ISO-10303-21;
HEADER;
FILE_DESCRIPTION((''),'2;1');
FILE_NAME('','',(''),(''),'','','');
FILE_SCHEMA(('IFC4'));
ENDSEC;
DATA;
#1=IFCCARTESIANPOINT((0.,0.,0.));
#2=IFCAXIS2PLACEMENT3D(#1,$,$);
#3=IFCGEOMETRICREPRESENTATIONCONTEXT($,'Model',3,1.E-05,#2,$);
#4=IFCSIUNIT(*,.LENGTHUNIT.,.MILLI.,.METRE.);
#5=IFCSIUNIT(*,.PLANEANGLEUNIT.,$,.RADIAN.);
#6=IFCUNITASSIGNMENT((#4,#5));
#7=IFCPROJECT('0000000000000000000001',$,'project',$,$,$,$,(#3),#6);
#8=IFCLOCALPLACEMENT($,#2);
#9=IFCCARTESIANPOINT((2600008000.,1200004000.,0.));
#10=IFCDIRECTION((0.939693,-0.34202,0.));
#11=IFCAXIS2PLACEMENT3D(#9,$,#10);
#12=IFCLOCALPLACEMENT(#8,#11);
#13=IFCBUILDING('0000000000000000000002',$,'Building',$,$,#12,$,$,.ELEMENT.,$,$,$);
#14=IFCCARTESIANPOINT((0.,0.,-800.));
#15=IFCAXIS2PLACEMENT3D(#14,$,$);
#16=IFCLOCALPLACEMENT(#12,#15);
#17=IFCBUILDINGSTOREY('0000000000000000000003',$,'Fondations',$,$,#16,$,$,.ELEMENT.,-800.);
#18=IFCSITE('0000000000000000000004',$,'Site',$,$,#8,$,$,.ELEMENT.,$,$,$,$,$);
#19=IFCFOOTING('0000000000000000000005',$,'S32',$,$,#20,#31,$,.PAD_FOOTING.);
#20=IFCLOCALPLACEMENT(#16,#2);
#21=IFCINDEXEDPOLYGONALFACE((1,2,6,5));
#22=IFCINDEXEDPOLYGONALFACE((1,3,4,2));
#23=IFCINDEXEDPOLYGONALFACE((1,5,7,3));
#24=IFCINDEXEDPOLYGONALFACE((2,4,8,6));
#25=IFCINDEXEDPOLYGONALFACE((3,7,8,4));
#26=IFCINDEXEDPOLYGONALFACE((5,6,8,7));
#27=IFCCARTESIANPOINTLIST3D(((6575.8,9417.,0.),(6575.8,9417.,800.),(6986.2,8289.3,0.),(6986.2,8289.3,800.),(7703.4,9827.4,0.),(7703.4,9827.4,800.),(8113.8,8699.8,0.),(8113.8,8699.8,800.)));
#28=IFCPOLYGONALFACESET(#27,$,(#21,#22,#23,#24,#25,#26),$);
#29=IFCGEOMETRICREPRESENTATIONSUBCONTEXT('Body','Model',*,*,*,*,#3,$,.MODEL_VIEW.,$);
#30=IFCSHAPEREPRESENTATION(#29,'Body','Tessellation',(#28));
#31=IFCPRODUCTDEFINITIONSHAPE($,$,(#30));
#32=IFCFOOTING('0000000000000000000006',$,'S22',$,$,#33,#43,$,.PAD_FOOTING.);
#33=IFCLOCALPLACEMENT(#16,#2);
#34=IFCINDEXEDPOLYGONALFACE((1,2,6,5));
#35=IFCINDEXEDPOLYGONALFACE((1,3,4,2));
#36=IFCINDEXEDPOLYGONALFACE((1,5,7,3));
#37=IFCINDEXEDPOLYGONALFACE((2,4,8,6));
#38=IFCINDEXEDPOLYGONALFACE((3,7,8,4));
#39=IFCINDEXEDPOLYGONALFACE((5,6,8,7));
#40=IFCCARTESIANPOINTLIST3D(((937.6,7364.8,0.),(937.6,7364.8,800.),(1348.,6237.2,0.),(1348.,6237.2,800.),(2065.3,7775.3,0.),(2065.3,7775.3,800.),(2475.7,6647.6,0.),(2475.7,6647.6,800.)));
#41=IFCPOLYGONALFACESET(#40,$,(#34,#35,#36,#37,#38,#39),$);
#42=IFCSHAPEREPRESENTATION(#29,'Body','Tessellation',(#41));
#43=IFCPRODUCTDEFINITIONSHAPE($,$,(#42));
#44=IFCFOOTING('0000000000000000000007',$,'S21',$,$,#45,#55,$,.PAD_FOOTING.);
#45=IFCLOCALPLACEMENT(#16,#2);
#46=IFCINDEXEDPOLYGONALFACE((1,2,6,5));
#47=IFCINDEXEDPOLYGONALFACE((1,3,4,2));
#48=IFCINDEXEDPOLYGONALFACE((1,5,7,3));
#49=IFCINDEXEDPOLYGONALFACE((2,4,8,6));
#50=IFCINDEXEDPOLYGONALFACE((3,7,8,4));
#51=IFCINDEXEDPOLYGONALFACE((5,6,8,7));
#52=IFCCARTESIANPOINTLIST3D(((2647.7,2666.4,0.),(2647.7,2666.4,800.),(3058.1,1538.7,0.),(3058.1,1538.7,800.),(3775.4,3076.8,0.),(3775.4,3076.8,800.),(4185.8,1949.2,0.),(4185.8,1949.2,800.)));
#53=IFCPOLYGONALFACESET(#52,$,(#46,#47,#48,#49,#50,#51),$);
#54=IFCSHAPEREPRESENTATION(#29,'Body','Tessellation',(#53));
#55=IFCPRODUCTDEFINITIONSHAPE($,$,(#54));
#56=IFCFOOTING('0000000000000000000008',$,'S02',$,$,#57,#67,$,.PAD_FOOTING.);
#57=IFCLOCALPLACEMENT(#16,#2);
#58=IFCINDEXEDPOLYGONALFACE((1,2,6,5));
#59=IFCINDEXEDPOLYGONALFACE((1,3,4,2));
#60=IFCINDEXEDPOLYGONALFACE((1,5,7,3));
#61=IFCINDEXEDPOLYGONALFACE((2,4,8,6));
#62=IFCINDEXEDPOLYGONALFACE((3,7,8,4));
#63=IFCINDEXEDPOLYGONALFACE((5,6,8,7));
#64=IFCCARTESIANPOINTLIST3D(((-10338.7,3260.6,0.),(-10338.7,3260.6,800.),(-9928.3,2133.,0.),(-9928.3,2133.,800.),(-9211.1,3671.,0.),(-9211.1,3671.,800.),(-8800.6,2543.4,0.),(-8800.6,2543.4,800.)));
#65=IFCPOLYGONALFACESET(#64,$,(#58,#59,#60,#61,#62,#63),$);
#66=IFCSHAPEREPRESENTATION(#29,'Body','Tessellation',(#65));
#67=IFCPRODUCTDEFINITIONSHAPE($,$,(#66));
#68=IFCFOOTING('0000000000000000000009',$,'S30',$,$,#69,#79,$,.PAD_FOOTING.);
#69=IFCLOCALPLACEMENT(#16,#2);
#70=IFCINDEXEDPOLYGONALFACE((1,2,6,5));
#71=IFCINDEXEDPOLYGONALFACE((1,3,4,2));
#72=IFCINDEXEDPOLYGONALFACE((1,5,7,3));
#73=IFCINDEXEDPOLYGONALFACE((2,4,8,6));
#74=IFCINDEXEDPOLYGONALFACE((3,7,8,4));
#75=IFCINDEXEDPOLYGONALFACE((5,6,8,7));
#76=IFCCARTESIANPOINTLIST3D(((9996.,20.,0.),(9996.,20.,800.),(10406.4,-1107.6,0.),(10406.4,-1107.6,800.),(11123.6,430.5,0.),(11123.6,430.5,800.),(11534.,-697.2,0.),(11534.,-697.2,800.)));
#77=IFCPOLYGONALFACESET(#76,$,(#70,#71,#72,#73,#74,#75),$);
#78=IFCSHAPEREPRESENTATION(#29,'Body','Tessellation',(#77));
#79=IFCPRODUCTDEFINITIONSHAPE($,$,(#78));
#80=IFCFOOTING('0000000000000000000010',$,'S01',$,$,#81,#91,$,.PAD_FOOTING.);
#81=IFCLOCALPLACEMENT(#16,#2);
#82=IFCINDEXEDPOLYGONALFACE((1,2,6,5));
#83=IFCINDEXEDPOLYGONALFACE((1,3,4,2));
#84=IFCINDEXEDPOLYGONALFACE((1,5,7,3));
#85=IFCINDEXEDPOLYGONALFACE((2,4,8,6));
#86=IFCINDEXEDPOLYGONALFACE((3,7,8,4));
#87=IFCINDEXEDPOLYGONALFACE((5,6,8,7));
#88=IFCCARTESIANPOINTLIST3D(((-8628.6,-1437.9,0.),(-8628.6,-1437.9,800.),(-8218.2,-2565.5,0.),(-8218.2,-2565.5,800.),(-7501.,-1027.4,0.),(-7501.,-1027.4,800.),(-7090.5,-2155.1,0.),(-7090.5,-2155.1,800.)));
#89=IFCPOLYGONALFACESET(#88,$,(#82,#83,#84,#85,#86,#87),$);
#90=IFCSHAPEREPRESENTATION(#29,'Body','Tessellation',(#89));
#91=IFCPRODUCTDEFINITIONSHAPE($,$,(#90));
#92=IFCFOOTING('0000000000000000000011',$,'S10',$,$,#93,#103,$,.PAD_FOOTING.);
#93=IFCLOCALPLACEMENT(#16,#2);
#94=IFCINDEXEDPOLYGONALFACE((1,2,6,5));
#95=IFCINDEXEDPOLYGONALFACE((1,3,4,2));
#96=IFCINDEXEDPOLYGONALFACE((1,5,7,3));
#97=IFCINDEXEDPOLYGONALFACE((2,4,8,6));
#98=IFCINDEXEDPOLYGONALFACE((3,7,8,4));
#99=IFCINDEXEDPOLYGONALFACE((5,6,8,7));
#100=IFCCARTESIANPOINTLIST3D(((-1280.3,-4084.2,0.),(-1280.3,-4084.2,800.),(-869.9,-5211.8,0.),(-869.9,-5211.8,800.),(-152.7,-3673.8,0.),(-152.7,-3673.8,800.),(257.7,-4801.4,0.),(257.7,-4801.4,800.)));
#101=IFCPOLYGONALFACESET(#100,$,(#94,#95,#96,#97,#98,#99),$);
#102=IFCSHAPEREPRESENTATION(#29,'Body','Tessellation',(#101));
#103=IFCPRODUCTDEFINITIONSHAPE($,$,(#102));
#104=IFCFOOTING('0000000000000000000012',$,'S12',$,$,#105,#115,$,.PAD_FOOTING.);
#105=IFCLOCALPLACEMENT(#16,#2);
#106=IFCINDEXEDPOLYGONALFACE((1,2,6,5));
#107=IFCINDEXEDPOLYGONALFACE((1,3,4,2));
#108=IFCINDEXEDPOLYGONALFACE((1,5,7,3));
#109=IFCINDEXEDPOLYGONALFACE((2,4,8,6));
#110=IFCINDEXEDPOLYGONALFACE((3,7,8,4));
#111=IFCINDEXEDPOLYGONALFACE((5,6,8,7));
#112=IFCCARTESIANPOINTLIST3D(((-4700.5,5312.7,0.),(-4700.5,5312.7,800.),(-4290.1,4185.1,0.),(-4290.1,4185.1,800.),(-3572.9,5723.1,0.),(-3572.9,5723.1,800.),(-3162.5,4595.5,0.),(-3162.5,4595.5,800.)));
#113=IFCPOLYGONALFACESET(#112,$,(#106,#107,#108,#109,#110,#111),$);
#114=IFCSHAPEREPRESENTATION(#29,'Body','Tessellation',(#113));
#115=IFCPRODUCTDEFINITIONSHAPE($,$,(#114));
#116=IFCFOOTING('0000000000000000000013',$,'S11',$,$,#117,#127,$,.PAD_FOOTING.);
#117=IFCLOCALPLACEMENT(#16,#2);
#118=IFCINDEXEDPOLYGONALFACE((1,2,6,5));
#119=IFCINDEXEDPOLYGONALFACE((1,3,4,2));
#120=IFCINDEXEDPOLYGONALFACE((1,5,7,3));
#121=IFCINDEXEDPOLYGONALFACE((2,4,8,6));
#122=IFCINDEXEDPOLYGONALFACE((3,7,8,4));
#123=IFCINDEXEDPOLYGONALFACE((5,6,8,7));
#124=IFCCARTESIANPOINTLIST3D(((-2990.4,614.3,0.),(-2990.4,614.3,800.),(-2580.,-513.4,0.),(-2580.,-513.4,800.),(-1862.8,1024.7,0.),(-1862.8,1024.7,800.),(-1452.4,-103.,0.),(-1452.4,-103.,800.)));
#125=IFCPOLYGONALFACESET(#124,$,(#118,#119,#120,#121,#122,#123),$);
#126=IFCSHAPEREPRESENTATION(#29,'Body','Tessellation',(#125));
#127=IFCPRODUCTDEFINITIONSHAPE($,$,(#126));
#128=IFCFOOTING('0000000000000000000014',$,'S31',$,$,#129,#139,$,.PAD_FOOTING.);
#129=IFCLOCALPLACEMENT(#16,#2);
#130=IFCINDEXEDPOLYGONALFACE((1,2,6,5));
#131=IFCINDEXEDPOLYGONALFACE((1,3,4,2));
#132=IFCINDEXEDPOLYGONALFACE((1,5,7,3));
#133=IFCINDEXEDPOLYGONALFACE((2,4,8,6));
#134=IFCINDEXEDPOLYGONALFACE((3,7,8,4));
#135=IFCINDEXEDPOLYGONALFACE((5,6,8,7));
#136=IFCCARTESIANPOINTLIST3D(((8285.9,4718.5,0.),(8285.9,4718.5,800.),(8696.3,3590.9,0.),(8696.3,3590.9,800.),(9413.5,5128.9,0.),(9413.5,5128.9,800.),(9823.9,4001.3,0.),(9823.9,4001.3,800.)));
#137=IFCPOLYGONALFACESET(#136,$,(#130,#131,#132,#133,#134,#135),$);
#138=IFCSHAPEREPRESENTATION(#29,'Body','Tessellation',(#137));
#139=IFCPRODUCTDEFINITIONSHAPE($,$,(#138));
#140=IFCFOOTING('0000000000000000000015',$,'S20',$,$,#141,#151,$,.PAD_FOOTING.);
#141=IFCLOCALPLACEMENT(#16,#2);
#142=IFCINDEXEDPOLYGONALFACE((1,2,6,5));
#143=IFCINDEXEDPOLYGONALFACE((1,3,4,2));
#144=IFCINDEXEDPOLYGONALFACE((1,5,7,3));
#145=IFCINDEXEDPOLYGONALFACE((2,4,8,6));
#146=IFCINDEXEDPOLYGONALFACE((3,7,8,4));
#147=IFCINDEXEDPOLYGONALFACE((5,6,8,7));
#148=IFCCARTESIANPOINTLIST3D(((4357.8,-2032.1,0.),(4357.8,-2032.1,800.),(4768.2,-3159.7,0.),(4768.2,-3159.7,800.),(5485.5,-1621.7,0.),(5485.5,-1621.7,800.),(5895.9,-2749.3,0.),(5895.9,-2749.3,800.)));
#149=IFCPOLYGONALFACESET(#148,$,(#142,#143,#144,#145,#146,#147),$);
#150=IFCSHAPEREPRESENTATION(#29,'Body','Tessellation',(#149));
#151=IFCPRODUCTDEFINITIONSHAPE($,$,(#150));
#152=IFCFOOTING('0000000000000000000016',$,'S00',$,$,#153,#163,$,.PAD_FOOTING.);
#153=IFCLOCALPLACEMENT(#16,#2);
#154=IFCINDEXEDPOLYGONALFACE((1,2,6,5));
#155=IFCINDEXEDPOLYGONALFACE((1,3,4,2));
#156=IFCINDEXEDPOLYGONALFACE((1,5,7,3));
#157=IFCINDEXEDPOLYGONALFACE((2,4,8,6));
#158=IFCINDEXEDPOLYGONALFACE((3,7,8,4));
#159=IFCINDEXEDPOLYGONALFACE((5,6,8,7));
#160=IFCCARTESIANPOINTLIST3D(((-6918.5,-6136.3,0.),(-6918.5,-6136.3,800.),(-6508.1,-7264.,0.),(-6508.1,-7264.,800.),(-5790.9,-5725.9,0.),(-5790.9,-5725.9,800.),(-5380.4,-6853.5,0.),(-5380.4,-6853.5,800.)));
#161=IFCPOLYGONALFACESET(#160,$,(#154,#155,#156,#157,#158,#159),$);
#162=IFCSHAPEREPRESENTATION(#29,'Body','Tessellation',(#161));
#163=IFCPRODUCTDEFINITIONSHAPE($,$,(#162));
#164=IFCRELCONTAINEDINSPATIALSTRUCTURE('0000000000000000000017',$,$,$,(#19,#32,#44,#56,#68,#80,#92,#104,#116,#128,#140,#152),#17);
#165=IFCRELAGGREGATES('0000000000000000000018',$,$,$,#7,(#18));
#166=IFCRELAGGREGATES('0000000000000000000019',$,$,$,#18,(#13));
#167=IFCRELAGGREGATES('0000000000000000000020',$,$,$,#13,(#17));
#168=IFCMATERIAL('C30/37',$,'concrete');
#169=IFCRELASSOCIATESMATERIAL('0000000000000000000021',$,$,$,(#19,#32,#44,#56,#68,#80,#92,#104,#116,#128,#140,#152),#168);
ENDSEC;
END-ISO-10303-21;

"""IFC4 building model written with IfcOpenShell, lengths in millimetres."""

from ifc_helpers import new_model, si_unit, frame, origin, place, context, subcontext, project, spatial, rectangle, extrude, material, element, save


model = new_model("IFC4")

# Units and contexts
model_context = context("Model", 3, precision=1e-05, world=origin())
body_context = subcontext(model_context, "Body", "Model", "MODEL_VIEW")
ifc_project = project(units=[si_unit("LENGTHUNIT", "METRE", prefix="MILLI"), si_unit("PLANEANGLEUNIT", "RADIAN")], contexts=[model_context])

# Site, building, storey
site_placement = place(None, origin())
site = spatial("IfcSite", under=ifc_project, at=site_placement, Name="Site", CompositionType="ELEMENT")
building_placement = place(site_placement, frame((2600008000.0, 1200004000.0, 0.0), x_axis=(0.939693, -0.34202, 0.0)))
building = spatial("IfcBuilding", under=site, at=building_placement, Name="Building", CompositionType="ELEMENT")
storey_placement = place(building_placement, frame((0.0, 0.0, -800.0)))
storey = spatial("IfcBuildingStorey", under=building, at=storey_placement, Name="Fondations", CompositionType="ELEMENT", Elevation=-800.0)

# Footings
ifc_material = material(Name="C30/37", Category="concrete")
for number, where, z_axis, x_axis, name in (
    (1, (7344.8, 9058.4, 0.0), (0.0, 0.0, 1.0), (0.939693, 0.34202, 0.0), "S32"),
    (2, (1706.6, 7006.2, 0.0), (0.0, 0.0, 1.0), (0.939693, 0.34202, 0.0), "S22"),
    (3, (3416.8, 2307.8, 0.0), (0.0, 0.0, 1.0), (0.939693, 0.34202, 0.0), "S21"),
    (4, (-9569.7, 2902.0, 0.0), (0.0, 0.0, 1.0), (0.939693, 0.34202, 0.0), "S02"),
    (5, (10765.0, -338.6, 0.0), (0.0, 0.0, 1.0), (0.939693, 0.34202, 0.0), "S30"),
    (6, (-7859.6, -1796.5, 0.0), (0.0, 0.0, 1.0), (0.939693, 0.34202, 0.0), "S01"),
    (7, (-511.3, -4442.8, 0.0), (0.0, 0.0, 1.0), (0.939693, 0.34202, 0.0), "S10"),
    (8, (-3931.5, 4954.1, 0.0), (0.0, 0.0, 1.0), (0.939693, 0.34202, 0.0), "S12"),
    (9, (-2221.4, 255.7, 0.0), (0.0, 0.0, 1.0), (0.939693, 0.34202, 0.0), "S11"),
    (10, (9054.9, 4359.9, 0.0), (0.0, 0.0, 1.0), (0.939693, 0.34202, 0.0), "S31"),
    (11, (5126.9, -2390.7, 0.0), (0.0, 0.0, 1.0), (0.939693, 0.34202, 0.0), "S20"),
    (12, (-6149.5, -6494.9, 0.0), (0.0, 0.0, 1.0), (0.939693, 0.34202, 0.0), "S00"),
):
    element("IfcFooting", number, at=place(storey_placement, frame(where, z_axis=z_axis, x_axis=x_axis)), inside=storey, material=ifc_material, Name=name, PredefinedType="PAD_FOOTING", context=body_context, shape_type="SweptSolid", body=[
        extrude(rectangle(XDim=1200.0, YDim=1200.0), origin(), (0.0, 0.0, 1.0), 800.0),
    ])

save(model, "model.ifc")
